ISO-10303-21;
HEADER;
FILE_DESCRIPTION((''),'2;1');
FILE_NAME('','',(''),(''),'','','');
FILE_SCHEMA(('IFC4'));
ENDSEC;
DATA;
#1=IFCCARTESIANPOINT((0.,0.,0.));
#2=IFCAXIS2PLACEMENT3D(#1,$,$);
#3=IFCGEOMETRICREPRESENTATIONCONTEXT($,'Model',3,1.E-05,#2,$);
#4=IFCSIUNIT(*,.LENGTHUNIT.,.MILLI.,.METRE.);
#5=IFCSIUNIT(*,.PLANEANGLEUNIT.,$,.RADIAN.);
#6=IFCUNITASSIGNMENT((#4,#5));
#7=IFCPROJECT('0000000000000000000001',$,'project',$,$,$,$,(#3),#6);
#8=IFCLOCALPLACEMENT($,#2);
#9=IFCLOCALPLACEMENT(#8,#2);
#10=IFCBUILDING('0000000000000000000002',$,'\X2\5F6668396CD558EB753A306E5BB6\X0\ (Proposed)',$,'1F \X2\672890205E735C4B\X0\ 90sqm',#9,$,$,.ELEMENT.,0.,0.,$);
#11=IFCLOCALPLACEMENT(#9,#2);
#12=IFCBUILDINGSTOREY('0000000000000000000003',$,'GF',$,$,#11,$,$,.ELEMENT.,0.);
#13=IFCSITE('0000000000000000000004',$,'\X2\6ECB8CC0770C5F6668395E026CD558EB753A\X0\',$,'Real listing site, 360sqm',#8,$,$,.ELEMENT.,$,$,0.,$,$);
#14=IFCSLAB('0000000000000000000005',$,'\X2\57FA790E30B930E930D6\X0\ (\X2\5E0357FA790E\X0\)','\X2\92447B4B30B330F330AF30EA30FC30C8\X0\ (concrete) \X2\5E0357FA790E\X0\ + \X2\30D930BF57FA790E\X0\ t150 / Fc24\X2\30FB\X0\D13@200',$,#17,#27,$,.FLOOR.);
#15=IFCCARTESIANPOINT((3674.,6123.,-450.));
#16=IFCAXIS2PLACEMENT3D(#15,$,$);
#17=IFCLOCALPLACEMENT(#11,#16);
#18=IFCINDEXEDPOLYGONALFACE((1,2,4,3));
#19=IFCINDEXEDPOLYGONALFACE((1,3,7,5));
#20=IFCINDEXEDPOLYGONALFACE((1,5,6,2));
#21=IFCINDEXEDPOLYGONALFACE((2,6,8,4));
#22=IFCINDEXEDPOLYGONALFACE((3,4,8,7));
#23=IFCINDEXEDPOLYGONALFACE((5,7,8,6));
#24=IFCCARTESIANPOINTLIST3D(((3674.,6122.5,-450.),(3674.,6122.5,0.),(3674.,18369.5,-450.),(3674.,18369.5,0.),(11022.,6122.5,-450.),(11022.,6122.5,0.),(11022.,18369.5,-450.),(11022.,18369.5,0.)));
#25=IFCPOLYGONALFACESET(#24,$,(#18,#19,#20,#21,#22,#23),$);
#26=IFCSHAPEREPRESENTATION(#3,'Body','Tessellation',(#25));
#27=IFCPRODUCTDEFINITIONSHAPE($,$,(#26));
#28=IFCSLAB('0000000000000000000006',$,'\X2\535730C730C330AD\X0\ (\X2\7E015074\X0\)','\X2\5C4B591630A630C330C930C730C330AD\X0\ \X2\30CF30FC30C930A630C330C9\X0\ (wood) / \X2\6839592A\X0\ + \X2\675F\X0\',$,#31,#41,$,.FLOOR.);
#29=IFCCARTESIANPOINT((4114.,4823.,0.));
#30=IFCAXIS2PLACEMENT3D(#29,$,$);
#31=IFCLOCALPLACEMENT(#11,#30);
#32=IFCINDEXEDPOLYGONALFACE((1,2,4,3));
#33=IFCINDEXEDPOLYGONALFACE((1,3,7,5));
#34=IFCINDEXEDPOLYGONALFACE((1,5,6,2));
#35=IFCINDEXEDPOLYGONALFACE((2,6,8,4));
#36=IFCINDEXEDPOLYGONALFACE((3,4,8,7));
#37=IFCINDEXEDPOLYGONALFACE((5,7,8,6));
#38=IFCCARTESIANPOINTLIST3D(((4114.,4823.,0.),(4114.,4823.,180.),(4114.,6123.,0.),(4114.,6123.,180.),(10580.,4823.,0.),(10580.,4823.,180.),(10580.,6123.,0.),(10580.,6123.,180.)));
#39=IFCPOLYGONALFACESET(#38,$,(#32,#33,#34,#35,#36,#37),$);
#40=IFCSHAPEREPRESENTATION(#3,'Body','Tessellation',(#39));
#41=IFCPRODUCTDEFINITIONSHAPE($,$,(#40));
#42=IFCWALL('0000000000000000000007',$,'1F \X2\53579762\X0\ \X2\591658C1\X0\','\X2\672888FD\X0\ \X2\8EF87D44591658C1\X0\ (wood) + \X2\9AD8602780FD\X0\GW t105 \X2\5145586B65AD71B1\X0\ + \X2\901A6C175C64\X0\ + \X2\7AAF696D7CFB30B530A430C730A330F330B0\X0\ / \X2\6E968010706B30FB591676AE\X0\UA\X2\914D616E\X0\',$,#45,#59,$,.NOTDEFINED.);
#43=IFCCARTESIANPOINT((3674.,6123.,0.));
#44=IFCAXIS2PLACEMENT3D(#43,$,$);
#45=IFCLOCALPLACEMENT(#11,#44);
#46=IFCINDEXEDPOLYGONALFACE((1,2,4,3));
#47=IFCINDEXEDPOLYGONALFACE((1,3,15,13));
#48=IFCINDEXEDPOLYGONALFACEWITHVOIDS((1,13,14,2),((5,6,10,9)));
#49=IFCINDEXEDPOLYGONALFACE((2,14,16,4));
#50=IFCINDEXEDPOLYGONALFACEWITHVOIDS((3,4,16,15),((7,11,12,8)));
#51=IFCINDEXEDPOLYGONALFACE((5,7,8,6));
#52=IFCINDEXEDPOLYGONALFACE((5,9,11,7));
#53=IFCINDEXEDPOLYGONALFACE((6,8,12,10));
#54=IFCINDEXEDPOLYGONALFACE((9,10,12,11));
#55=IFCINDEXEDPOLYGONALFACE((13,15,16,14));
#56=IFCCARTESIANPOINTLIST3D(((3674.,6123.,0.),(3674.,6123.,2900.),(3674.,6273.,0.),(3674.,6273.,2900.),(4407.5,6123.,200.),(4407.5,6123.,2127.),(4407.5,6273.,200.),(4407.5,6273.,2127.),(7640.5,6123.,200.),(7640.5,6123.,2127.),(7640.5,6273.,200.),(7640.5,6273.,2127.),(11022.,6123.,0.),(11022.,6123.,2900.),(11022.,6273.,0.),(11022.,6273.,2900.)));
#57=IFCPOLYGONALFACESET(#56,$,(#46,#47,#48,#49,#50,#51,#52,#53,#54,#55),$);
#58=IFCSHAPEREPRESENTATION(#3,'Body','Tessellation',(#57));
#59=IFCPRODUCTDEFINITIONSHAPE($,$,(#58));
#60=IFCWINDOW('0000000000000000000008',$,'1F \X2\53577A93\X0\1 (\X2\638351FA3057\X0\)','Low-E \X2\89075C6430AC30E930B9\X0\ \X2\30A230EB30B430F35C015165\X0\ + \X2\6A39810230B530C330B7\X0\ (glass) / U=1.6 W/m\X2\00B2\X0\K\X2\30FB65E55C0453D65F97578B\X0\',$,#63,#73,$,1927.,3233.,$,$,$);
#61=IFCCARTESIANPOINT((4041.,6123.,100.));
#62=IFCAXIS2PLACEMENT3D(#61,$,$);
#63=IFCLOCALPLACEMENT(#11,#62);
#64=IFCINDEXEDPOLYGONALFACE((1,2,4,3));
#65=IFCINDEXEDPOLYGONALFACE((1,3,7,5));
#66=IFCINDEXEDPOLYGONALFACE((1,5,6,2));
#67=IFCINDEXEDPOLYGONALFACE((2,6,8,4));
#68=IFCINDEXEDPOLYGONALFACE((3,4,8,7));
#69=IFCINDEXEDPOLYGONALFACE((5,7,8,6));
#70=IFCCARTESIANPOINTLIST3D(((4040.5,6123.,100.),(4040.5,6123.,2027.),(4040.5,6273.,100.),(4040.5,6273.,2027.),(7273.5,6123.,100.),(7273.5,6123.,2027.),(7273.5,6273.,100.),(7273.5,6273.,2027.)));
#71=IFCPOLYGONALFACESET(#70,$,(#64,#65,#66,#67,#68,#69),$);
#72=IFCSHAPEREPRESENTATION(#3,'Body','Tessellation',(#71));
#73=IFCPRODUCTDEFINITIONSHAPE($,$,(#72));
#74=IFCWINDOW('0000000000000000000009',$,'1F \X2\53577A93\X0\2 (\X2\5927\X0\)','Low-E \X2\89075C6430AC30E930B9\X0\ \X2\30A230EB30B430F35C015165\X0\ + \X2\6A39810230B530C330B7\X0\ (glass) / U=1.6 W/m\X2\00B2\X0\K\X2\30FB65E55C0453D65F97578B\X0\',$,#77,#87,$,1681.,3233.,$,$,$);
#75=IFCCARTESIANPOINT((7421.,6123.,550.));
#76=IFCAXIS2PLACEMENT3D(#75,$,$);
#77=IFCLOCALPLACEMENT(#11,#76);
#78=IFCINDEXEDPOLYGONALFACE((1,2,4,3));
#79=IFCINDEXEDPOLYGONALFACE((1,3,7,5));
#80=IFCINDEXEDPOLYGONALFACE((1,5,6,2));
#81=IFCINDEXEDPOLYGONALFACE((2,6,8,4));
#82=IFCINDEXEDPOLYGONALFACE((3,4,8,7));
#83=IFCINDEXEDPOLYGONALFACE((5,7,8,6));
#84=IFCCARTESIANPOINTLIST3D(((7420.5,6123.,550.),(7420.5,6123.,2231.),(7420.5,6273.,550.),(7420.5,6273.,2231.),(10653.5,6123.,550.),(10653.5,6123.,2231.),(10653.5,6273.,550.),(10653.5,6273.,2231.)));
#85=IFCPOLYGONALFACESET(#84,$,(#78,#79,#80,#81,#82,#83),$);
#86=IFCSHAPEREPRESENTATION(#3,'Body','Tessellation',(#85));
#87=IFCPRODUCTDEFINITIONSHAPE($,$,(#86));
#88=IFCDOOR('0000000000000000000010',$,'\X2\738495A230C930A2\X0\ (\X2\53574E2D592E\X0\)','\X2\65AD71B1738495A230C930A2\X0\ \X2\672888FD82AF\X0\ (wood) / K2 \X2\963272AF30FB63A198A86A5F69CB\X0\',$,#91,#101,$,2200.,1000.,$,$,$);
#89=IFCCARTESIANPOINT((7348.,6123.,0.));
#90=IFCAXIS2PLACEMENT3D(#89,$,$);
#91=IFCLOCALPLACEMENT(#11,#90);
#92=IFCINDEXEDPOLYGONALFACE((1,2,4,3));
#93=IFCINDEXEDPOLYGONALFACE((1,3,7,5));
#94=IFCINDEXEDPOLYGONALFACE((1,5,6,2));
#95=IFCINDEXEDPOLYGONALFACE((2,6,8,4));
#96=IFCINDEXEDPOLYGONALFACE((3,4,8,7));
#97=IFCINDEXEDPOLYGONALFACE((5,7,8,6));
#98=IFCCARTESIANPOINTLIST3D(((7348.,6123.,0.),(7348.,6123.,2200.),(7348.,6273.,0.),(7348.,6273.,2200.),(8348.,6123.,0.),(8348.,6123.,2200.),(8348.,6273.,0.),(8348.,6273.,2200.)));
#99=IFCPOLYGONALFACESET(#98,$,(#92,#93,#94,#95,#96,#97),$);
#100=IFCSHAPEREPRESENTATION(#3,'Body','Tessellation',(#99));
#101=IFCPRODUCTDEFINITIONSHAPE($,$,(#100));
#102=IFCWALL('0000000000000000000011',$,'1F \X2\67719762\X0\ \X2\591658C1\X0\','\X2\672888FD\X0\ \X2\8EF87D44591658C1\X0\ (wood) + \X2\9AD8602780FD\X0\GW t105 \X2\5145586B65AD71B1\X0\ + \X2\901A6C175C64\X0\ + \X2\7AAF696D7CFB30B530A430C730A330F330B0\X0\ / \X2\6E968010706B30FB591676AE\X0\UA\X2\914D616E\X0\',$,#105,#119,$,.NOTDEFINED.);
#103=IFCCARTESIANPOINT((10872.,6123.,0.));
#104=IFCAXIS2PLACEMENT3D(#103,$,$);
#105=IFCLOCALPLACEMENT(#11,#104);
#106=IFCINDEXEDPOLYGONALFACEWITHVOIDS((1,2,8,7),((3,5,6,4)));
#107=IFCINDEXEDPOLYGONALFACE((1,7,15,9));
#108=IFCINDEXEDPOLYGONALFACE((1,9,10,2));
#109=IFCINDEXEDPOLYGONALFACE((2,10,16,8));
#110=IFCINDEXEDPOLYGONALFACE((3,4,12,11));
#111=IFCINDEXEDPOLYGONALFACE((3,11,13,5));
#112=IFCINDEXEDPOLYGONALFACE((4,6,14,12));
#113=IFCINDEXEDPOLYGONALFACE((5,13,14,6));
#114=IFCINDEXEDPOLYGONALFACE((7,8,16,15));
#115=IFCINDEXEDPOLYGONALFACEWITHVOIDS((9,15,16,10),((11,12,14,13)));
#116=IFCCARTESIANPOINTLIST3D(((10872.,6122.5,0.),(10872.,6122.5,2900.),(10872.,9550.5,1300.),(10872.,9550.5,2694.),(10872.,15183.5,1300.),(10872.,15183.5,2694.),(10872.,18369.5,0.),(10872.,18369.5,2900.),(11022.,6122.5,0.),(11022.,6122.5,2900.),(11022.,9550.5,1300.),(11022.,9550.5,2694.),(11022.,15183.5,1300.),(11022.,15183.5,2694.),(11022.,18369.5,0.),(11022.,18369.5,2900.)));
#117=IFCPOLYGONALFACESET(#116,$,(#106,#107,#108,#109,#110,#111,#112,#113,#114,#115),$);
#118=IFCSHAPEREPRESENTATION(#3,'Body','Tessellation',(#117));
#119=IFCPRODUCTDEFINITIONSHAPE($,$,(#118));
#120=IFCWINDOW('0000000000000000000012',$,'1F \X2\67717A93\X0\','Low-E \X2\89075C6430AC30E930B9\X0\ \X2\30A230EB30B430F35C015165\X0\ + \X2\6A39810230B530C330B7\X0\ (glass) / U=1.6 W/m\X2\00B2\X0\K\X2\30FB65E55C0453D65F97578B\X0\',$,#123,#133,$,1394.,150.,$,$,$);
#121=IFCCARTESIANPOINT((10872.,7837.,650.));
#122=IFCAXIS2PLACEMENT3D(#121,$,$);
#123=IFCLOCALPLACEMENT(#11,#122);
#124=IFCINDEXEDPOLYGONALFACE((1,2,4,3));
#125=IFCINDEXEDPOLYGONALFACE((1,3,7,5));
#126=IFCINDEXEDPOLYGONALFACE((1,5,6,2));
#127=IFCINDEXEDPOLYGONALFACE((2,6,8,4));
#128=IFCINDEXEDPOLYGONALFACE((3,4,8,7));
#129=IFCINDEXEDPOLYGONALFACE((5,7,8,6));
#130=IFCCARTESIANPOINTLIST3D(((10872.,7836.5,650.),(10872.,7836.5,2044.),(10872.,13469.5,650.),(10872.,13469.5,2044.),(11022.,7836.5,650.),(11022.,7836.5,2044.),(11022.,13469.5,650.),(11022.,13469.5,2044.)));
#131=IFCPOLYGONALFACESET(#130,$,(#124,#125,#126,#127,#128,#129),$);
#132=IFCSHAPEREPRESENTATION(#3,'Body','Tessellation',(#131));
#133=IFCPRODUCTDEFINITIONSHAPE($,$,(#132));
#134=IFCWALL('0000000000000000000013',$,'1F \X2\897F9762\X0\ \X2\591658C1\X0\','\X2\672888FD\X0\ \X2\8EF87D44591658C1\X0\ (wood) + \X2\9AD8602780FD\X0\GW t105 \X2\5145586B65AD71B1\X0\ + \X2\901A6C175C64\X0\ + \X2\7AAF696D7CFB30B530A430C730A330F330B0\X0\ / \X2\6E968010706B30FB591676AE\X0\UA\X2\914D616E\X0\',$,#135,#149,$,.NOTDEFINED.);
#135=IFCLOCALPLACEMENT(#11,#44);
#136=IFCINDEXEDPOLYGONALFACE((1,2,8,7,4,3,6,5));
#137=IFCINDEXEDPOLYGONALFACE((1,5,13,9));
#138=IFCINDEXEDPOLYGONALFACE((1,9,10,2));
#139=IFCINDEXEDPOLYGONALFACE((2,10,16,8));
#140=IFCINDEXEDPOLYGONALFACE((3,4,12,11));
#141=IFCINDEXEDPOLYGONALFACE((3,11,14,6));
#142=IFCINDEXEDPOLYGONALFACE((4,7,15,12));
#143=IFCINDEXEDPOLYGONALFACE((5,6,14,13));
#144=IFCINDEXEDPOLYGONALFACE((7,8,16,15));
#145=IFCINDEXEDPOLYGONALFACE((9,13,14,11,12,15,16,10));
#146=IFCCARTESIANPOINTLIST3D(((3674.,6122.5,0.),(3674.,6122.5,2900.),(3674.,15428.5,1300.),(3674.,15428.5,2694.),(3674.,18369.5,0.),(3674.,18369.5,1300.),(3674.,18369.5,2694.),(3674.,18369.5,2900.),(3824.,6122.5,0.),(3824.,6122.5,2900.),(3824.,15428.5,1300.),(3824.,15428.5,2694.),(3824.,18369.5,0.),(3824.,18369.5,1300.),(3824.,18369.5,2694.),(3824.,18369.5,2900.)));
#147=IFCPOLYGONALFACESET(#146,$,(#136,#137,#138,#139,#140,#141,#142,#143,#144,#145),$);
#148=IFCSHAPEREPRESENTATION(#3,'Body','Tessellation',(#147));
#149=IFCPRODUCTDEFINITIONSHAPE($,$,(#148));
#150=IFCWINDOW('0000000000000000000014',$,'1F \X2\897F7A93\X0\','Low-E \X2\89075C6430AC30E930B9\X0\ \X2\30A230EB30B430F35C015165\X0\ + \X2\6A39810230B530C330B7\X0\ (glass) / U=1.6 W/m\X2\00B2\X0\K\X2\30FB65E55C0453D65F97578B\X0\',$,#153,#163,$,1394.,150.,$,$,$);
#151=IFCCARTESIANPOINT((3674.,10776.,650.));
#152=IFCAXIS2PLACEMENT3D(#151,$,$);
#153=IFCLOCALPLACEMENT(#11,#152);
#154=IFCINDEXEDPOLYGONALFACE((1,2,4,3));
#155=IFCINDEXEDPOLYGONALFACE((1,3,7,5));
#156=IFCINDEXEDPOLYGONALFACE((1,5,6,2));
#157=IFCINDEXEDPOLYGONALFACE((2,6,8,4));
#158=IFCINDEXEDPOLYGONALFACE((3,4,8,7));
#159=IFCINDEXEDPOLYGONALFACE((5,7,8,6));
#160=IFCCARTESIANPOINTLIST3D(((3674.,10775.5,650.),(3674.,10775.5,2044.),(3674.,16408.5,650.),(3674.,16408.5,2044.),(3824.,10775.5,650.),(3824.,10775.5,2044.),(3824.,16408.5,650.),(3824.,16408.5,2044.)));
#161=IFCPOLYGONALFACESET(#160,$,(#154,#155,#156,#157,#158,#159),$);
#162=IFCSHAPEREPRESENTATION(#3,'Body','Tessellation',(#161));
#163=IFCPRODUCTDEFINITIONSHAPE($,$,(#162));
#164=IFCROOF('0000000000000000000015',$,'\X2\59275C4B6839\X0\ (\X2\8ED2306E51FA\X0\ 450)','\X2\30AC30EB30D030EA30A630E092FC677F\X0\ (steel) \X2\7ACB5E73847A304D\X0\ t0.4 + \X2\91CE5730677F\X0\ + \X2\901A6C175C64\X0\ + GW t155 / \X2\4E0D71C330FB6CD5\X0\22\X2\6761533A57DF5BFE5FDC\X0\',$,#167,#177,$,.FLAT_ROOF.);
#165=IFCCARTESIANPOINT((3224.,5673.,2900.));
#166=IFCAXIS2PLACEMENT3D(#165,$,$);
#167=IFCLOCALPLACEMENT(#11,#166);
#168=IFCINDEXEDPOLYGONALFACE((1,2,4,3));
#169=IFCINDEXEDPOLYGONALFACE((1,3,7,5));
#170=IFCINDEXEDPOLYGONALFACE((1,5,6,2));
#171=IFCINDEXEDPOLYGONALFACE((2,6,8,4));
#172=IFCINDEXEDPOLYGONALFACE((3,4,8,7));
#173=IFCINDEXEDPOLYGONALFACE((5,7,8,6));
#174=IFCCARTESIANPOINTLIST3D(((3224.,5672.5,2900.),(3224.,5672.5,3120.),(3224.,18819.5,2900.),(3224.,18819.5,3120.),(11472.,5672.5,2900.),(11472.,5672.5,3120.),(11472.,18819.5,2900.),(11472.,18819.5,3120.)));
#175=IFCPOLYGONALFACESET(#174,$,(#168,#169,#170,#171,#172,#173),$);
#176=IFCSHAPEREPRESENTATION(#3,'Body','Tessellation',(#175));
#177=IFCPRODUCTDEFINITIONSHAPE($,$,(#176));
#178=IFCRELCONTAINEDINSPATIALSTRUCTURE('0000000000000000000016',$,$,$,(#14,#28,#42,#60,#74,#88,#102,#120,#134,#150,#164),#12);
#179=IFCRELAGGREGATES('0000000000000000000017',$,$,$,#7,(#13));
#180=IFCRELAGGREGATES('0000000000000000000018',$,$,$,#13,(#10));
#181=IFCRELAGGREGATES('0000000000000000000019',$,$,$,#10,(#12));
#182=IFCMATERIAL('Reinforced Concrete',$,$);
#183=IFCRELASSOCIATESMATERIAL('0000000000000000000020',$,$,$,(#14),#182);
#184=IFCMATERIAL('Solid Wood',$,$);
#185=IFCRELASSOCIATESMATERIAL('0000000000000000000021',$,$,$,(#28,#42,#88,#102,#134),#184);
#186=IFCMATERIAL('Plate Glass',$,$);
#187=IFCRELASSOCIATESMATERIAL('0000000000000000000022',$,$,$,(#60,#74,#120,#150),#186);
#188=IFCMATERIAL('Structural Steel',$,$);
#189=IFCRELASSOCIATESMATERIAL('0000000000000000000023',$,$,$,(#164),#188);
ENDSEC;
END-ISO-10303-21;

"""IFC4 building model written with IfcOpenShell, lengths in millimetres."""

from ifc_helpers import new_model, si_unit, frame, frame_2d, origin, place, context, project, spatial, rectangle, extrude, material, element, fill, save


model = new_model("IFC4")

# Units and contexts
model_context = context("Model", 3, precision=1e-05, world=origin())
ifc_project = project(units=[si_unit("LENGTHUNIT", "METRE", prefix="MILLI"), si_unit("PLANEANGLEUNIT", "RADIAN")], contexts=[model_context])

# Site, building, storey
site_placement = place(None, origin())
site = spatial("IfcSite", under=ifc_project, at=site_placement, Name="滋賀県彦根市法士町", ObjectType="Real listing site, 360sqm", CompositionType="ELEMENT", RefElevation=0.0)
building_placement = place(site_placement, origin())
building = spatial("IfcBuilding", under=site, at=building_placement, Name="彦根法士町の家 (Proposed)", ObjectType="1F 木造平屋 90sqm", CompositionType="ELEMENT", ElevationOfRefHeight=0.0, ElevationOfTerrain=0.0)
storey_placement = place(building_placement, origin())
storey = spatial("IfcBuildingStorey", under=building, at=storey_placement, Name="GF", CompositionType="ELEMENT", Elevation=0.0)

# Slabs
ifc_material_1 = material(Name="Reinforced Concrete")
slab_1_placement = place(storey_placement, frame((3674.0, 6123.0, -450.0)))
element("IfcSlab", 1, at=slab_1_placement, inside=storey, material=ifc_material_1, Name="基礎スラブ (布基礎)", Description="鉄筋コンクリート (concrete) 布基礎 + ベタ基礎 t150 / Fc24・D13@200", PredefinedType="FLOOR", context=model_context, shape_type="SweptSolid", body=[
    extrude(rectangle(XDim=7348.0, YDim=12247.0, at=frame_2d((3674.0, 6123.0))), frame((3674.0, 6123.0, -450.0)), (0.0, 0.0, 1.0), 450.0),
])
ifc_material_2 = material(Name="Solid Wood")
slab_2_placement = place(storey_placement, frame((4114.0, 4823.0, 0.0)))
element("IfcSlab", 2, at=slab_2_placement, inside=storey, material=ifc_material_2, Name="南デッキ (縁側)", Description="屋外ウッドデッキ ハードウッド (wood) / 根太 + 束", PredefinedType="FLOOR", context=model_context, shape_type="SweptSolid", body=[
    extrude(rectangle(XDim=6466.0, YDim=1300.0, at=frame_2d((3233.0, 650.0))), frame((4114.0, 4823.0, 0.0)), (0.0, 0.0, 1.0), 180.0),
])

# Wall, openings, windows, door
wall_1_placement = place(storey_placement, frame((3674.0, 6123.0, 0.0)))
wall_1 = element("IfcWall", 3, at=wall_1_placement, inside=storey, material=ifc_material_2, Name="1F 南面 外壁", Description="木製 軸組外壁 (wood) + 高性能GW t105 充填断熱 + 通気層 + 窯業系サイディング / 準耐火・外皮UA配慮", PredefinedType="NOTDEFINED", context=model_context, shape_type="SweptSolid", body=[
    extrude(rectangle(XDim=7348.0, YDim=150.0, at=frame_2d((3674.0, 75.0))), frame((3674.0, 6123.0, 0.0)), (0.0, 0.0, 1.0), 2900.0),
])
opening_1_placement = place(storey_placement, frame((4041.0, 6123.0, 100.0)))
opening_1 = element("IfcOpeningElement", 4, at=opening_1_placement, cuts=wall_1, PredefinedType="NOTDEFINED", context=model_context, shape_type="SweptSolid", body=[
    extrude(rectangle(XDim=3233.0, YDim=150.0, at=frame_2d((1616.0, 75.0))), frame((4041.0, 6123.0, 100.0)), (0.0, 0.0, 1.0), 1927.0),
])
opening_2_placement = place(storey_placement, frame((7421.0, 6123.0, 550.0)))
opening_2 = element("IfcOpeningElement", 5, at=opening_2_placement, cuts=wall_1, PredefinedType="NOTDEFINED", context=model_context, shape_type="SweptSolid", body=[
    extrude(rectangle(XDim=3233.0, YDim=150.0, at=frame_2d((1616.0, 75.0))), frame((7421.0, 6123.0, 550.0)), (0.0, 0.0, 1.0), 1681.0),
])
opening_3_placement = place(storey_placement, frame((7348.0, 6123.0, 0.0)))
opening_3 = element("IfcOpeningElement", 6, at=opening_3_placement, cuts=wall_1, PredefinedType="NOTDEFINED", context=model_context, shape_type="SweptSolid", body=[
    extrude(rectangle(XDim=1000.0, YDim=150.0, at=frame_2d((500.0, 75.0))), frame((7348.0, 6123.0, 0.0)), (0.0, 0.0, 1.0), 2200.0),
])
ifc_material_3 = material(Name="Plate Glass")
window_1_placement = place(storey_placement, frame((4041.0, 6123.0, 100.0)))
window_1 = element("IfcWindow", 7, at=window_1_placement, inside=storey, material=ifc_material_3, Name="1F 南窓1 (掃出し)", Description="Low-E 複層ガラス アルゴン封入 + 樹脂サッシ (glass) / U=1.6 W/m²K・日射取得型", OverallHeight=1927.0, OverallWidth=3233.0, context=model_context, shape_type="SweptSolid", body=[
    extrude(rectangle(XDim=3233.0, YDim=150.0, at=frame_2d((1616.0, 75.0))), frame((4041.0, 6123.0, 100.0)), (0.0, 0.0, 1.0), 1927.0),
])
fill(opening_1, window_1)
window_2_placement = place(storey_placement, frame((7421.0, 6123.0, 550.0)))
window_2 = element("IfcWindow", 8, at=window_2_placement, inside=storey, material=ifc_material_3, Name="1F 南窓2 (大)", Description="Low-E 複層ガラス アルゴン封入 + 樹脂サッシ (glass) / U=1.6 W/m²K・日射取得型", OverallHeight=1681.0, OverallWidth=3233.0, context=model_context, shape_type="SweptSolid", body=[
    extrude(rectangle(XDim=3233.0, YDim=150.0, at=frame_2d((1616.0, 75.0))), frame((7421.0, 6123.0, 550.0)), (0.0, 0.0, 1.0), 1681.0),
])
fill(opening_2, window_2)
door_placement = place(storey_placement, frame((7348.0, 6123.0, 0.0)))
door = element("IfcDoor", 9, at=door_placement, inside=storey, material=ifc_material_2, Name="玄関ドア (南中央)", Description="断熱玄関ドア 木製芯 (wood) / K2 防犯・採風機構", OverallHeight=2200.0, OverallWidth=1000.0, context=model_context, shape_type="SweptSolid", body=[
    extrude(rectangle(XDim=1000.0, YDim=150.0, at=frame_2d((500.0, 75.0))), frame((7348.0, 6123.0, 0.0)), (0.0, 0.0, 1.0), 2200.0),
])
fill(opening_3, door)

# Walls, openings, windows
wall_2_placement = place(storey_placement, frame((10872.0, 6123.0, 0.0)))
wall_2 = element("IfcWall", 10, at=wall_2_placement, inside=storey, material=ifc_material_2, Name="1F 東面 外壁", Description="木製 軸組外壁 (wood) + 高性能GW t105 充填断熱 + 通気層 + 窯業系サイディング / 準耐火・外皮UA配慮", PredefinedType="NOTDEFINED", context=model_context, shape_type="SweptSolid", body=[
    extrude(rectangle(XDim=150.0, YDim=12247.0, at=frame_2d((75.0, 6123.0))), frame((10872.0, 6123.0, 0.0)), (0.0, 0.0, 1.0), 2900.0),
])
opening_4_placement = place(storey_placement, frame((10872.0, 7837.0, 650.0)))
opening_4 = element("IfcOpeningElement", 11, at=opening_4_placement, cuts=wall_2, PredefinedType="NOTDEFINED", context=model_context, shape_type="SweptSolid", body=[
    extrude(rectangle(XDim=150.0, YDim=5633.0, at=frame_2d((75.0, 2816.0))), frame((10872.0, 7837.0, 650.0)), (0.0, 0.0, 1.0), 1394.0),
])
window_3_placement = place(storey_placement, frame((10872.0, 7837.0, 650.0)))
window_3 = element("IfcWindow", 12, at=window_3_placement, inside=storey, material=ifc_material_3, Name="1F 東窓", Description="Low-E 複層ガラス アルゴン封入 + 樹脂サッシ (glass) / U=1.6 W/m²K・日射取得型", OverallHeight=1394.0, OverallWidth=150.0, context=model_context, shape_type="SweptSolid", body=[
    extrude(rectangle(XDim=150.0, YDim=5633.0, at=frame_2d((75.0, 2816.0))), frame((10872.0, 7837.0, 650.0)), (0.0, 0.0, 1.0), 1394.0),
])
fill(opening_4, window_3)
wall_3_placement = place(storey_placement, frame((3674.0, 6123.0, 0.0)))
wall_3 = element("IfcWall", 13, at=wall_3_placement, inside=storey, material=ifc_material_2, Name="1F 西面 外壁", Description="木製 軸組外壁 (wood) + 高性能GW t105 充填断熱 + 通気層 + 窯業系サイディング / 準耐火・外皮UA配慮", PredefinedType="NOTDEFINED", context=model_context, shape_type="SweptSolid", body=[
    extrude(rectangle(XDim=150.0, YDim=12247.0, at=frame_2d((75.0, 6123.0))), frame((3674.0, 6123.0, 0.0)), (0.0, 0.0, 1.0), 2900.0),
])
opening_5_placement = place(storey_placement, frame((3674.0, 10776.0, 650.0)))
opening_5 = element("IfcOpeningElement", 14, at=opening_5_placement, cuts=wall_3, PredefinedType="NOTDEFINED", context=model_context, shape_type="SweptSolid", body=[
    extrude(rectangle(XDim=150.0, YDim=5633.0, at=frame_2d((75.0, 2816.0))), frame((3674.0, 10776.0, 650.0)), (0.0, 0.0, 1.0), 1394.0),
])
window_4_placement = place(storey_placement, frame((3674.0, 10776.0, 650.0)))
window_4 = element("IfcWindow", 15, at=window_4_placement, inside=storey, material=ifc_material_3, Name="1F 西窓", Description="Low-E 複層ガラス アルゴン封入 + 樹脂サッシ (glass) / U=1.6 W/m²K・日射取得型", OverallHeight=1394.0, OverallWidth=150.0, context=model_context, shape_type="SweptSolid", body=[
    extrude(rectangle(XDim=150.0, YDim=5633.0, at=frame_2d((75.0, 2816.0))), frame((3674.0, 10776.0, 650.0)), (0.0, 0.0, 1.0), 1394.0),
])
fill(opening_5, window_4)

# Roof
ifc_material_4 = material(Name="Structural Steel")
roof_placement = place(storey_placement, frame((3224.0, 5673.0, 2900.0)))
element("IfcRoof", 16, at=roof_placement, inside=storey, material=ifc_material_4, Name="大屋根 (軒の出 450)", Description="ガルバリウム鋼板 (steel) 立平葺き t0.4 + 野地板 + 通気層 + GW t155 / 不燃・法22条区域対応", PredefinedType="FLAT_ROOF", context=model_context, shape_type="SweptSolid", body=[
    extrude(rectangle(XDim=8248.0, YDim=13147.0, at=frame_2d((4124.0, 6573.0))), frame((3224.0, 5673.0, 2900.0)), (0.0, 0.0, 1.0), 220.0),
])

save(model, "model.ifc")
